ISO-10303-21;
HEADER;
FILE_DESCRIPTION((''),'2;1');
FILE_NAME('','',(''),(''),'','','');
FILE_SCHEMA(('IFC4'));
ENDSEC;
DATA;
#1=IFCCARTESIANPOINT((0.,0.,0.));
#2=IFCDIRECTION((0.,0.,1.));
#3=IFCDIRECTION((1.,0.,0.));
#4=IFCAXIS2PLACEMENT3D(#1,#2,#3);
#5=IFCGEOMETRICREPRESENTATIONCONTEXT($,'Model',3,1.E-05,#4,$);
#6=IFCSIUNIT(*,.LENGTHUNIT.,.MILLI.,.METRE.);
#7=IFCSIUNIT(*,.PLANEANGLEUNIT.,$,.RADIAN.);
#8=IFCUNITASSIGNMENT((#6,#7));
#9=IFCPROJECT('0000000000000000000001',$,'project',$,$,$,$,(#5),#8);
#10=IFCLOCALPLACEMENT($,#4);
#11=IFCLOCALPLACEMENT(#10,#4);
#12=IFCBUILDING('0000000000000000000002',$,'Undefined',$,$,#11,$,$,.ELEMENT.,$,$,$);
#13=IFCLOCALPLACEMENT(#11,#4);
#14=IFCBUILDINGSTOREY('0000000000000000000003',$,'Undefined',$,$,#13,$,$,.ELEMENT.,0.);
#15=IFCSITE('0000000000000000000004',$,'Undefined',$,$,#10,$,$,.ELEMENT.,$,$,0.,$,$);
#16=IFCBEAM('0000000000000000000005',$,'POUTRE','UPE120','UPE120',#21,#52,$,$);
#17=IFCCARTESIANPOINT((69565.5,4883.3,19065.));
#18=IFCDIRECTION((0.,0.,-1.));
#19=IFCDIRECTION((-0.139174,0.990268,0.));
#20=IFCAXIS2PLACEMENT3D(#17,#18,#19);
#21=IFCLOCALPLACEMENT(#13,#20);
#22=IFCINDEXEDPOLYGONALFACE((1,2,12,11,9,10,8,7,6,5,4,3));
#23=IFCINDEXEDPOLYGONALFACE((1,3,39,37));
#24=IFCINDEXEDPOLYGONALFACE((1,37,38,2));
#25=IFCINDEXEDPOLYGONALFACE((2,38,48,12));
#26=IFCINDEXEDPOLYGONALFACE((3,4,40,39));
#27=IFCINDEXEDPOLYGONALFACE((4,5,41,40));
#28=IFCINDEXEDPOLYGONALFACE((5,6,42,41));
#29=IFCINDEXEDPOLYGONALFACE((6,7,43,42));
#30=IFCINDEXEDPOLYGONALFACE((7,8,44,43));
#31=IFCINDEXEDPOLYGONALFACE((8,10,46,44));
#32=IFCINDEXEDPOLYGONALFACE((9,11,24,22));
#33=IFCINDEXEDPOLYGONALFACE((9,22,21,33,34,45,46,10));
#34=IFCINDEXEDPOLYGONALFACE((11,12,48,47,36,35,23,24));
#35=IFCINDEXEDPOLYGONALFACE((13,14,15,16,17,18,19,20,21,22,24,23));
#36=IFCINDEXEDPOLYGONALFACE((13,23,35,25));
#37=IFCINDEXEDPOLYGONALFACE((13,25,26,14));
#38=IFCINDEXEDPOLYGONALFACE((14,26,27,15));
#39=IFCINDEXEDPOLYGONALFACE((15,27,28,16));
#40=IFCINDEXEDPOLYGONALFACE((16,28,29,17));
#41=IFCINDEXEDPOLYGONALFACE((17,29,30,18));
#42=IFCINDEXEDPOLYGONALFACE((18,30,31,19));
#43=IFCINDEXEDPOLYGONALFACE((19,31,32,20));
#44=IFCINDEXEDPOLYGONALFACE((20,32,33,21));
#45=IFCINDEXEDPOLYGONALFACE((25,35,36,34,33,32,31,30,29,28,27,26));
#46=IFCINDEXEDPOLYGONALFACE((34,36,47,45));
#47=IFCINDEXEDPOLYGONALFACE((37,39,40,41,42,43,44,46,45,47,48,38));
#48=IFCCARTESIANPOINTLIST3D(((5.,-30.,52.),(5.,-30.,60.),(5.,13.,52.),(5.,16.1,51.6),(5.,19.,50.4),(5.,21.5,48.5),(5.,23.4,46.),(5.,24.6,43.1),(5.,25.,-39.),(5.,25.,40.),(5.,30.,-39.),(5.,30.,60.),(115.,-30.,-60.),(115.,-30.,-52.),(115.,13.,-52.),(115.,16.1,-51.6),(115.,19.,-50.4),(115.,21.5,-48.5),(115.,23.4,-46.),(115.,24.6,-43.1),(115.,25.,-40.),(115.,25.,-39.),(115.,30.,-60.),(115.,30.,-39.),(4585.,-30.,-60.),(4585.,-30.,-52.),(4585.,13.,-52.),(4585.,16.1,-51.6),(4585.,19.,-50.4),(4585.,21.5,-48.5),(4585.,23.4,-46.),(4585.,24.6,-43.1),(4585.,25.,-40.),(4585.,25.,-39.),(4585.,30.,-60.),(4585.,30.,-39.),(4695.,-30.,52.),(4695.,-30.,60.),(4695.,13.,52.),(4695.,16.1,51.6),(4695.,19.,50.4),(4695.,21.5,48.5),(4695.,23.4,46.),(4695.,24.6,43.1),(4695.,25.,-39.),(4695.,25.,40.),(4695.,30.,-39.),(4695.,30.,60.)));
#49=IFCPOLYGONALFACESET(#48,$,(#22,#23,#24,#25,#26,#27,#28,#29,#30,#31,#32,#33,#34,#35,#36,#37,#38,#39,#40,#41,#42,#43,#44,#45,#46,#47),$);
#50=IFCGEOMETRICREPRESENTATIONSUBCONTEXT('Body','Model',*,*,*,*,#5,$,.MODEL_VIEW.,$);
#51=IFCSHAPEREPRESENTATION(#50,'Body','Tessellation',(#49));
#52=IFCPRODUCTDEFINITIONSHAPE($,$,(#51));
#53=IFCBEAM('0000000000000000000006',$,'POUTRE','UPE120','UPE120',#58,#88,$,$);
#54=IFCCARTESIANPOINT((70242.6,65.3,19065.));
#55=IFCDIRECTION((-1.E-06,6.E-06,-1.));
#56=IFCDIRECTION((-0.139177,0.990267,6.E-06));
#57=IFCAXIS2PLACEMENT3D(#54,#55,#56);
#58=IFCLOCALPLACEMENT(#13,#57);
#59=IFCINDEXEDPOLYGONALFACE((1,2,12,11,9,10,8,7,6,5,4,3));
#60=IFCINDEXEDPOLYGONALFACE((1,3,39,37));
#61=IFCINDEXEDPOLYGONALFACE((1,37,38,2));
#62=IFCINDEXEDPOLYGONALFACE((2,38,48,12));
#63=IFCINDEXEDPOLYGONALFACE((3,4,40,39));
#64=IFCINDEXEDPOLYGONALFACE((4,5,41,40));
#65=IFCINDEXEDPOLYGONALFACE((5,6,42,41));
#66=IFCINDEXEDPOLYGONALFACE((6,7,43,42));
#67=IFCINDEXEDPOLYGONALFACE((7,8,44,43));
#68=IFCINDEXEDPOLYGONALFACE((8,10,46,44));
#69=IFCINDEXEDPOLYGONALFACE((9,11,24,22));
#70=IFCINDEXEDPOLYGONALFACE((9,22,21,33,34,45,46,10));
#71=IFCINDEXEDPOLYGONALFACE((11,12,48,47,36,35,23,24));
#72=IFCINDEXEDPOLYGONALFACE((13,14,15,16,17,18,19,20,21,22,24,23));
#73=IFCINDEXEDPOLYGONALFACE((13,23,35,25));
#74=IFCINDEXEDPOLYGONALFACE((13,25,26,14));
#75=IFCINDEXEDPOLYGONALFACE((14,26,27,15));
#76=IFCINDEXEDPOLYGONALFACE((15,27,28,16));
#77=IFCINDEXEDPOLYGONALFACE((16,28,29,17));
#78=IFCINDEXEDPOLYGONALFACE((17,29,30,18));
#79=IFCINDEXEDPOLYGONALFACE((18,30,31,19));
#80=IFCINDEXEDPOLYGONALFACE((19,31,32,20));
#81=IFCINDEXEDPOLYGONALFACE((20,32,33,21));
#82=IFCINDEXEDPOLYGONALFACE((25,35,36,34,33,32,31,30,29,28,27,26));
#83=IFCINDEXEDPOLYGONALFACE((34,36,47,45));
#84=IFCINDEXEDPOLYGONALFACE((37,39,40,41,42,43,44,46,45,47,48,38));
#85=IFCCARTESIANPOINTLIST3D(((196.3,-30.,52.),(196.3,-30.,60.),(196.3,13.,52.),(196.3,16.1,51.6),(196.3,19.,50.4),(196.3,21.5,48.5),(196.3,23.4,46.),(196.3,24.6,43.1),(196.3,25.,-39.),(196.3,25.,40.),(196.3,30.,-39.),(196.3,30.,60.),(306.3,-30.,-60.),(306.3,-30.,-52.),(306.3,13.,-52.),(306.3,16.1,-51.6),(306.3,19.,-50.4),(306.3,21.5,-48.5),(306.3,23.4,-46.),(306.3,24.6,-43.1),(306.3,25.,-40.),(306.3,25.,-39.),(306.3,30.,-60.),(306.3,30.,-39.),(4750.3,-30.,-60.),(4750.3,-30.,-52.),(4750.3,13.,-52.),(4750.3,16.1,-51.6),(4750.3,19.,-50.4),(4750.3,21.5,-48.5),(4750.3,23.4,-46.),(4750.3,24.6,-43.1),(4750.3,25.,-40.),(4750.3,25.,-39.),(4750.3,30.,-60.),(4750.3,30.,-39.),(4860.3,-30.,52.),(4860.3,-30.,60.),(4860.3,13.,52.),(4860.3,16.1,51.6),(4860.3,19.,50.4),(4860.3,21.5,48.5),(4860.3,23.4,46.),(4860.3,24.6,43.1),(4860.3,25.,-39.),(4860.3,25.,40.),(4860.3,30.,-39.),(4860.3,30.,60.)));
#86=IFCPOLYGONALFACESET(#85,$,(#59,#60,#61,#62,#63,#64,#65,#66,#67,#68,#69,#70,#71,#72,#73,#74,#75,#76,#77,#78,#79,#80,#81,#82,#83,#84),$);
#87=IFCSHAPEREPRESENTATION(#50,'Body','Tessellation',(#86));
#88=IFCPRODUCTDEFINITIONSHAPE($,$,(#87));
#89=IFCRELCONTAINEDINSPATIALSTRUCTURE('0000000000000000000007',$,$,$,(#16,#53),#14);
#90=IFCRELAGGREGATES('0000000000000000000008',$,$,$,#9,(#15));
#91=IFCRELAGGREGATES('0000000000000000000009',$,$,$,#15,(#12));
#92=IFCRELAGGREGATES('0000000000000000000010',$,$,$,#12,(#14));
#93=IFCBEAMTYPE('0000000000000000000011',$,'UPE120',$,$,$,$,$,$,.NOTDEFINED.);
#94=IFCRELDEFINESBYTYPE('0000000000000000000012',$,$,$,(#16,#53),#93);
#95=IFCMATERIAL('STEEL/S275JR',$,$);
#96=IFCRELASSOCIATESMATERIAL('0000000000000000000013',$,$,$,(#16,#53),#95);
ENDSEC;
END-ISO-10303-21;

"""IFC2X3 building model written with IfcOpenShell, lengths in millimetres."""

from ifc_helpers import new_model, si_unit, frame, origin_with_axes, origin_2d_with_axis, place, context, subcontext, project, spatial, rectangle, u_section, extrude, boolean, material, type_object, element, save


model = new_model("IFC2X3")

# Units and contexts
model_context = context("Model", 3, precision=1e-05, world=origin_with_axes())
body_context = subcontext(model_context, "Body", "Model", "MODEL_VIEW")
ifc_project = project(units=[si_unit("LENGTHUNIT", "METRE", prefix="MILLI"), si_unit("PLANEANGLEUNIT", "RADIAN")], contexts=[model_context])

# Site, building, storey
site_placement = place(None, origin_with_axes())
site = spatial("IfcSite", under=ifc_project, at=site_placement, Name="Undefined", CompositionType="ELEMENT", RefElevation=0.0)
building_placement = place(site_placement, origin_with_axes())
building = spatial("IfcBuilding", under=site, at=building_placement, Name="Undefined", CompositionType="ELEMENT")
storey_placement = place(building_placement, origin_with_axes())
storey = spatial("IfcBuildingStorey", under=building, at=storey_placement, Name="Undefined", CompositionType="ELEMENT", Elevation=0.0)

# Shared definitions
ifc_material_1 = material(Name="STEEL/S275JR")

# Beams
beam_type_1 = type_object("IfcBeamType", Name="UPE120", PredefinedType="NOTDEFINED")
beam_1_placement = place(storey_placement, frame((69565.5, 4883.3, 19065.0), z_axis=(0.0, 0.0, -1.0), x_axis=(-0.139174, 0.990268, 0.0)))
element("IfcBeam", 1, at=beam_1_placement, inside=storey, type_object=beam_type_1, material=ifc_material_1, Name="POUTRE", Description="UPE120", ObjectType="UPE120", context=body_context, shape_type="CSG", body=[
    boolean("DIFFERENCE", boolean("DIFFERENCE", extrude(u_section(Depth=120.0, FlangeWidth=60.0, WebThickness=5.0, FlangeThickness=8.0, FilletRadius=12.0, at=origin_2d_with_axis()), frame((4695.0, 0.0, 0.0), z_axis=(-1.0, 0.0, 0.0), x_axis=(0.0, -1.0, 0.0)), (0.0, 0.0, 1.0), 4690.0), extrude(rectangle(XDim=22.0, YDim=112.0, at=origin_2d_with_axis()), frame((4641.0, -31.0, -50.0), z_axis=(0.000005, 1.0, 0.0), x_axis=(0.0, 0.0, 1.0)), (0.0, 0.0, 1.0), 62.0)), extrude(rectangle(XDim=22.0, YDim=112.0, at=origin_2d_with_axis()), frame((59.0, 31.0, -50.0), z_axis=(-0.000005, -1.0, 0.0), x_axis=(0.0, 0.0, 1.0)), (0.0, 0.0, 1.0), 62.0)),
])
beam_2_placement = place(storey_placement, frame((70242.6, 65.3, 19065.0), z_axis=(-0.000001, 0.000006, -1.0), x_axis=(-0.139177, 0.990267, 0.000006)))
element("IfcBeam", 2, at=beam_2_placement, inside=storey, type_object=beam_type_1, material=ifc_material_1, Name="POUTRE", Description="UPE120", ObjectType="UPE120", context=body_context, shape_type="CSG", body=[
    boolean("DIFFERENCE", boolean("DIFFERENCE", extrude(u_section(Depth=120.0, FlangeWidth=60.0, WebThickness=5.0, FlangeThickness=8.0, FilletRadius=12.0, at=origin_2d_with_axis()), frame((4860.3, 0.0, 0.0), z_axis=(-1.0, 0.0, 0.0), x_axis=(0.0, -1.0, 0.0)), (0.0, 0.0, 1.0), 4664.0), extrude(rectangle(XDim=22.0, YDim=112.0, at=origin_2d_with_axis()), frame((250.3, 31.0, -50.0), z_axis=(0.0, -1.0, 0.0), x_axis=(-0.000006, 0.0, 1.0)), (0.0, 0.0, 1.0), 62.0)), extrude(rectangle(XDim=22.0, YDim=112.0, at=origin_2d_with_axis()), frame((4806.3, -31.0, -50.0), z_axis=(0.0, 1.0, 0.0), x_axis=(-0.000006, 0.0, 1.0)), (0.0, 0.0, 1.0), 62.0)),
])

save(model, "model.ifc")
